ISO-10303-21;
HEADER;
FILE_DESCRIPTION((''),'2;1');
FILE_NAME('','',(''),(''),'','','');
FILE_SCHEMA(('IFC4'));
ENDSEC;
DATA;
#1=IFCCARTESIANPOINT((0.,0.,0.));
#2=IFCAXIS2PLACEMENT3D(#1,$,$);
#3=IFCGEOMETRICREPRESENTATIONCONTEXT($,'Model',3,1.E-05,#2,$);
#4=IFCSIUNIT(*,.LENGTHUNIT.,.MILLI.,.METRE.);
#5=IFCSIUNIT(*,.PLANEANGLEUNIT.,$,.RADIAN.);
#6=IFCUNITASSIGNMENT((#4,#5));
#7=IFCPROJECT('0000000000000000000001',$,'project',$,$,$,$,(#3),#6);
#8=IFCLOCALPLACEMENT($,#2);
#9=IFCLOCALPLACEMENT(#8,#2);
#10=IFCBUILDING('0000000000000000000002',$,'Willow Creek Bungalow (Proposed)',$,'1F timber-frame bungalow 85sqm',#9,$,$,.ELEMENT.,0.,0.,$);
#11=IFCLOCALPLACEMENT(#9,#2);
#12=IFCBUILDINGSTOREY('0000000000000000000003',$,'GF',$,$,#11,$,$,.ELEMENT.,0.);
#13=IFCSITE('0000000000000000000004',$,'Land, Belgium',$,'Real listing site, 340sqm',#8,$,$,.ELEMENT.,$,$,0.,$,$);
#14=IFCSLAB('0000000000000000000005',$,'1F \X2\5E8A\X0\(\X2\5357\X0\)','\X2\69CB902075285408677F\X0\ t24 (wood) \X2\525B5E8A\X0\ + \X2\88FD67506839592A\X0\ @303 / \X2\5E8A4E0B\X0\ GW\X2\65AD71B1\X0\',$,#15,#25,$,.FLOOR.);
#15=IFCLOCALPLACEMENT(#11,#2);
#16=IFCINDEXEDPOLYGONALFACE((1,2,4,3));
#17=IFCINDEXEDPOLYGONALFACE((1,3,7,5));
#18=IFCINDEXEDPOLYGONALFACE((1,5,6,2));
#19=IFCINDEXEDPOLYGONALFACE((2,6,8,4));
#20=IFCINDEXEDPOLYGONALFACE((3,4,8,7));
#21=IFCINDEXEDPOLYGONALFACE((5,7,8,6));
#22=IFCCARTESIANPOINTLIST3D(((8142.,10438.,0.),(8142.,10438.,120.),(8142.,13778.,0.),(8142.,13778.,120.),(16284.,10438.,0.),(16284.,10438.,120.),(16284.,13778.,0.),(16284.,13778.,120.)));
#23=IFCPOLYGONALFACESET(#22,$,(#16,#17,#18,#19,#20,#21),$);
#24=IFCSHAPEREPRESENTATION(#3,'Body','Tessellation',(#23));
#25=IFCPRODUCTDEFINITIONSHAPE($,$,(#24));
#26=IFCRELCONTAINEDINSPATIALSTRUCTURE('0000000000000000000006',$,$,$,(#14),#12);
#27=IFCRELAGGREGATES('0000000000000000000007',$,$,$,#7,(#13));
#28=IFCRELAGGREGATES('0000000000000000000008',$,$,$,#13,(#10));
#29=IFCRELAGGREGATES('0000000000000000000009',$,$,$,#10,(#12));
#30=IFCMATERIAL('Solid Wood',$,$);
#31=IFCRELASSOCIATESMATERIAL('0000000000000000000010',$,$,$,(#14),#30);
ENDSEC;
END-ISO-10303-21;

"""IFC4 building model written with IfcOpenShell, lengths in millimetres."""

from ifc_helpers import new_model, si_unit, frame, frame_2d, origin, place, context, project, spatial, rectangle, extrude, material, element, save


model = new_model("IFC4")

# Units and contexts
model_context = context("Model", 3, precision=1e-05, world=origin())
ifc_project = project(units=[si_unit("LENGTHUNIT", "METRE", prefix="MILLI"), si_unit("PLANEANGLEUNIT", "RADIAN")], contexts=[model_context])

# Site, building, storey
site_placement = place(None, origin())
site = spatial("IfcSite", under=ifc_project, at=site_placement, Name="Land, Belgium", ObjectType="Real listing site, 340sqm", CompositionType="ELEMENT", RefElevation=0.0)
building_placement = place(site_placement, origin())
building = spatial("IfcBuilding", under=site, at=building_placement, Name="Willow Creek Bungalow (Proposed)", ObjectType="1F timber-frame bungalow 85sqm", CompositionType="ELEMENT", ElevationOfRefHeight=0.0, ElevationOfTerrain=0.0)
storey_placement = place(building_placement, origin())
storey = spatial("IfcBuildingStorey", under=building, at=storey_placement, Name="GF", CompositionType="ELEMENT", Elevation=0.0)

# Shared definitions
ifc_material_1 = material(Name="Solid Wood")

# Slab
slab_1_placement = place(storey_placement, frame((4071.0, 5219.0, 0.0)))
element("IfcSlab", 1, at=slab_1_placement, inside=storey, material=ifc_material_1, Name="1F 床(南)", Description="構造用合板 t24 (wood) 剛床 + 製材根太 @303 / 床下 GW断熱", PredefinedType="FLOOR", context=model_context, shape_type="SweptSolid", body=[
    extrude(rectangle(XDim=8142.0, YDim=3340.0, at=frame_2d((4071.0, 1670.0))), frame((4071.0, 5219.0, 0.0)), (0.0, 0.0, 1.0), 120.0),
])

save(model, "model.ifc")
